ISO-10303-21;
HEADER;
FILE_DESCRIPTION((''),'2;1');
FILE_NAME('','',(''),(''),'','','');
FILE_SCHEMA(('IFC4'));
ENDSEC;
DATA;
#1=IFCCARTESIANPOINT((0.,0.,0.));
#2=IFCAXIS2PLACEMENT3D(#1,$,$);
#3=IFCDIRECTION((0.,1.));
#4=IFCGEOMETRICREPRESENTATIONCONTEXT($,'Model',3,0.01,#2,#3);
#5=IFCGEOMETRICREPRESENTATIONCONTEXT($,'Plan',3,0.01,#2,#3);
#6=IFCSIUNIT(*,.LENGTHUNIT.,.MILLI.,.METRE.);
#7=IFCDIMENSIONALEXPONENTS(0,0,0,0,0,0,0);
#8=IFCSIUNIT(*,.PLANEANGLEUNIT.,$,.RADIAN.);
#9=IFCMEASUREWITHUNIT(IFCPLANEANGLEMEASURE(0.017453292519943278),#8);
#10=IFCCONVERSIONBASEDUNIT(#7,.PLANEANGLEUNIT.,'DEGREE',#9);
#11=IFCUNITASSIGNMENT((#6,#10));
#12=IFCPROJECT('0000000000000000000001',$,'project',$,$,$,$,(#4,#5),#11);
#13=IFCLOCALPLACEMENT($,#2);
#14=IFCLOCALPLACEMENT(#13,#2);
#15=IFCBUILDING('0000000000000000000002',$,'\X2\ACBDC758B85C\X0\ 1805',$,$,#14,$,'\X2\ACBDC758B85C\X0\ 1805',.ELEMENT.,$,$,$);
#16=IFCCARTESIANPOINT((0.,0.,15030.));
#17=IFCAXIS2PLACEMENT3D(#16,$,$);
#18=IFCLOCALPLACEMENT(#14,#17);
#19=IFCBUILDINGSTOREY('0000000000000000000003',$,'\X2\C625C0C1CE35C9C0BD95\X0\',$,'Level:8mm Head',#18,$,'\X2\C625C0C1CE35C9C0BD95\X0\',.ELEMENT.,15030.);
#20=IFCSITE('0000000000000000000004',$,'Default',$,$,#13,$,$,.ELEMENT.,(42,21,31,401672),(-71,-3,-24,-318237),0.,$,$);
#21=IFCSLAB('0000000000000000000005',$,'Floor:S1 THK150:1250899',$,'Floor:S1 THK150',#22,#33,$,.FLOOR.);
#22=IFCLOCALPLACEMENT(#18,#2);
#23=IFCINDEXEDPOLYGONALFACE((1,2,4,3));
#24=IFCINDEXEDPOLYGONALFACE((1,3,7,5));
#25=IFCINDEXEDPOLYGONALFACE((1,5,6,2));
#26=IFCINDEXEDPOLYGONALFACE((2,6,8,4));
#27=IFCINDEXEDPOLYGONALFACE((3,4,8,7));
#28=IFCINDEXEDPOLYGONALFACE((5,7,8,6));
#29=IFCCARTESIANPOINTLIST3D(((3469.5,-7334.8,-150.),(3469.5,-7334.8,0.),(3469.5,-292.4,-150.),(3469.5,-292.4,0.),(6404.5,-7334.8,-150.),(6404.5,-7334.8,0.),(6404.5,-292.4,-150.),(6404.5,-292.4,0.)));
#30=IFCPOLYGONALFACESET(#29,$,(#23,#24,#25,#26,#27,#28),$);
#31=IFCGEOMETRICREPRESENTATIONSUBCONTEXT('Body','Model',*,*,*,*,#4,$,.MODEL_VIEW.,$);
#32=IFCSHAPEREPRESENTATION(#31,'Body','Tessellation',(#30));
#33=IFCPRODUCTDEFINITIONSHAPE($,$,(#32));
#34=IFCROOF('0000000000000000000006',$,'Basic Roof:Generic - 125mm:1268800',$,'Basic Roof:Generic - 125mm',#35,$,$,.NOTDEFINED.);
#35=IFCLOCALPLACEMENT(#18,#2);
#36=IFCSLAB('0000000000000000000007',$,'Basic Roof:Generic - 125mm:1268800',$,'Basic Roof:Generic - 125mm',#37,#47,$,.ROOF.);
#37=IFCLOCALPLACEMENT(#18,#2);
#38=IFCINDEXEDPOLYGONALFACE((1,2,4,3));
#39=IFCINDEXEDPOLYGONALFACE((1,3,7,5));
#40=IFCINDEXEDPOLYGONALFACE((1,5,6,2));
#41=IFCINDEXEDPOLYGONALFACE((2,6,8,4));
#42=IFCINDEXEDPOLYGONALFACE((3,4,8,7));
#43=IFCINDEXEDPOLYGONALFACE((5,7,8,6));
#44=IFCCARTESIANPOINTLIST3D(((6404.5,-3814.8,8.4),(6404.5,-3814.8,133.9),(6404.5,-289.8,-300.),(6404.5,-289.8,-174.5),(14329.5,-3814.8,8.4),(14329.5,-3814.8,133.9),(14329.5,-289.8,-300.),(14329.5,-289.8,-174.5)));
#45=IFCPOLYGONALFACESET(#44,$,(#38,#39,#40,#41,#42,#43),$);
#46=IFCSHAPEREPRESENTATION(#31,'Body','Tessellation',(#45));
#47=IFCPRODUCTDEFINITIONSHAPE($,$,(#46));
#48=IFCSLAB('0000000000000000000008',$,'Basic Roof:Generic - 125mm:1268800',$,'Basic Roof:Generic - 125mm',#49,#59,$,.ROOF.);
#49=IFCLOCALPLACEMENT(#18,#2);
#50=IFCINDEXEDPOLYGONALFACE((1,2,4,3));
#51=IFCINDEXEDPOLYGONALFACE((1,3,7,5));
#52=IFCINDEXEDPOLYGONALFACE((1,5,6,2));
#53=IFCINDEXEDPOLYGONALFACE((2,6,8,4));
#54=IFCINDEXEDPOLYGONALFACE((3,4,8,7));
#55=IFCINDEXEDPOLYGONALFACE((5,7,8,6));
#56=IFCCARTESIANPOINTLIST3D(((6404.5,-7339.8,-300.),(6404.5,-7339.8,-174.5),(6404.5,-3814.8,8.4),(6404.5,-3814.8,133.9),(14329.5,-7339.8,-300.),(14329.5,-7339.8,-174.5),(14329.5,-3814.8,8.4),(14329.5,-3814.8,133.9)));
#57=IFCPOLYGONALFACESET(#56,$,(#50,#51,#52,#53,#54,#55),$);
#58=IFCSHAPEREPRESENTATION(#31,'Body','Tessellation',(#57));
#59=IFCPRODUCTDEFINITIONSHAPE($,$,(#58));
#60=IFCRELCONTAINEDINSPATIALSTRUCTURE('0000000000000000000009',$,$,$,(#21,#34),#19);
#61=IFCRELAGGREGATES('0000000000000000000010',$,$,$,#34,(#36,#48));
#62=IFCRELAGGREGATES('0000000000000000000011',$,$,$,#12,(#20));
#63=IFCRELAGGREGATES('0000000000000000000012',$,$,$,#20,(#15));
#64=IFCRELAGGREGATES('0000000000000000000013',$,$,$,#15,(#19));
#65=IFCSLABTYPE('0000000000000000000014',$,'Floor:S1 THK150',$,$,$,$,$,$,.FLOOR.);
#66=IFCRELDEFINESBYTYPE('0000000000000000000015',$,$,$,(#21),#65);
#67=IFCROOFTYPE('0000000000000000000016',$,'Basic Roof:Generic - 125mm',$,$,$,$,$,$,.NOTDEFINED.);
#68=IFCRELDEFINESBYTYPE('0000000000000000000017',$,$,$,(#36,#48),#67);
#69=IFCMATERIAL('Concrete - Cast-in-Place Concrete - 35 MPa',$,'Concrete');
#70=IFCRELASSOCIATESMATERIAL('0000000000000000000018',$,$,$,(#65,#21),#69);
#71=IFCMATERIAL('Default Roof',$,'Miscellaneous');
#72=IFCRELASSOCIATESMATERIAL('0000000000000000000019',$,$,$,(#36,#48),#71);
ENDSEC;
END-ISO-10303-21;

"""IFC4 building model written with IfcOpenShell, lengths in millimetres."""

from ifc_helpers import new_model, entity, si_unit, converted_unit, direction, frame, origin, place, context, subcontext, project, spatial, indexed_curve, outline, extrude, material, type_object, element, aggregate, save


model = new_model("IFC4")

# Units and contexts
model_context = context("Model", 3, precision=0.01, world=origin(), true_north=direction((0.0, 1.0)))
plan_context = context("Plan", 3, precision=0.01, world=origin(), true_north=direction((0.0, 1.0)))
body_context = subcontext(model_context, "Body", "Model", "MODEL_VIEW")
ifc_project = project(units=[si_unit("LENGTHUNIT", "METRE", prefix="MILLI"), converted_unit("PLANEANGLEUNIT", "DEGREE", entity("IfcPlaneAngleMeasure", 0.017453292519943278), si_unit("PLANEANGLEUNIT", "RADIAN"), dimensions=[0, 0, 0, 0, 0, 0, 0])], contexts=[model_context, plan_context])

# Site, building, storey
site_placement = place(None, origin())
site = spatial("IfcSite", under=ifc_project, at=site_placement, Name="Default", CompositionType="ELEMENT", RefLatitude=(42, 21, 31, 401672), RefLongitude=(-71, -3, -24, -318237), RefElevation=0.0)
building_placement = place(site_placement, origin())
building = spatial("IfcBuilding", under=site, at=building_placement, Name="경의로 1805", LongName="경의로 1805", CompositionType="ELEMENT")
storey_placement = place(building_placement, frame((0.0, 0.0, 15030.0)))
storey = spatial("IfcBuildingStorey", under=building, at=storey_placement, Name="옥상층지붕", ObjectType="Level:8mm Head", LongName="옥상층지붕", CompositionType="ELEMENT", Elevation=15030.0)

# Slab
ifc_material_1 = material(Name="Concrete - Cast-in-Place Concrete - 35 MPa", Category="Concrete")
slab_type = type_object("IfcSlabType", Name="Floor:S1 THK150", PredefinedType="FLOOR", material=ifc_material_1)
slab_1_placement = place(storey_placement, origin())
element("IfcSlab", 1, at=slab_1_placement, inside=storey, type_object=slab_type, material=ifc_material_1, Name="Floor:S1 THK150:1250899", ObjectType="Floor:S1 THK150", PredefinedType="FLOOR", context=body_context, shape_type="SweptSolid", body=[
    extrude(outline(indexed_curve([(-3521.2, -1467.5), (3521.2, -1467.5), (3521.2, 1467.5), (-3521.2, 1467.5), (-3521.2, -1467.5)], self_intersect=False)), frame((4937.0, -3813.6, 0.0), z_axis=(0.0, 0.0, -1.0), x_axis=(0.0, 1.0, 0.0)), (0.0, 0.0, 1.0), 150.0),
])

# Roof, slabs
roof_placement = place(storey_placement, frame((6404.5, -7339.8, -300.0)))
roof = element("IfcRoof", 2, at=roof_placement, inside=storey, Name="Basic Roof:Generic - 125mm:1268800", ObjectType="Basic Roof:Generic - 125mm", PredefinedType="NOTDEFINED")
ifc_material_2 = material(Name="Default Roof", Category="Miscellaneous")
roof_type = type_object("IfcRoofType", Name="Basic Roof:Generic - 125mm", PredefinedType="NOTDEFINED")
slab_2_placement = place(roof_placement, origin())
slab_2 = element("IfcSlab", 3, at=slab_2_placement, type_object=roof_type, material=ifc_material_2, Name="Basic Roof:Generic - 125mm:1268800", ObjectType="Basic Roof:Generic - 125mm", PredefinedType="ROOF", context=body_context, shape_type="SweptSolid", body=[
    extrude(outline(indexed_curve([(-3962.5, -1769.2), (3962.5, -1769.2), (3962.5, 1769.2), (-3962.5, 1769.2), (-3962.5, -1769.2)], self_intersect=False)), frame((3962.5, 5287.5, 154.2), z_axis=(0.0, 0.087156, 0.996195), x_axis=(1.0, 0.0, 0.0)), (0.0, -0.087156, 0.996195), 125.5),
])
slab_3_placement = place(roof_placement, origin())
slab_3 = element("IfcSlab", 4, at=slab_3_placement, type_object=roof_type, material=ifc_material_2, Name="Basic Roof:Generic - 125mm:1268800", ObjectType="Basic Roof:Generic - 125mm", PredefinedType="ROOF", context=body_context, shape_type="SweptSolid", body=[
    extrude(outline(indexed_curve([(3962.5, -1769.2), (3962.5, 1769.2), (-3962.5, 1769.2), (-3962.5, -1769.2), (3962.5, -1769.2)], self_intersect=False)), frame((3962.5, 1762.5, 154.2), z_axis=(0.0, -0.087156, 0.996195), x_axis=(1.0, 0.0, 0.0)), (0.0, 0.087156, 0.996195), 125.5),
])
aggregate(roof, [slab_2, slab_3])

save(model, "model.ifc")
